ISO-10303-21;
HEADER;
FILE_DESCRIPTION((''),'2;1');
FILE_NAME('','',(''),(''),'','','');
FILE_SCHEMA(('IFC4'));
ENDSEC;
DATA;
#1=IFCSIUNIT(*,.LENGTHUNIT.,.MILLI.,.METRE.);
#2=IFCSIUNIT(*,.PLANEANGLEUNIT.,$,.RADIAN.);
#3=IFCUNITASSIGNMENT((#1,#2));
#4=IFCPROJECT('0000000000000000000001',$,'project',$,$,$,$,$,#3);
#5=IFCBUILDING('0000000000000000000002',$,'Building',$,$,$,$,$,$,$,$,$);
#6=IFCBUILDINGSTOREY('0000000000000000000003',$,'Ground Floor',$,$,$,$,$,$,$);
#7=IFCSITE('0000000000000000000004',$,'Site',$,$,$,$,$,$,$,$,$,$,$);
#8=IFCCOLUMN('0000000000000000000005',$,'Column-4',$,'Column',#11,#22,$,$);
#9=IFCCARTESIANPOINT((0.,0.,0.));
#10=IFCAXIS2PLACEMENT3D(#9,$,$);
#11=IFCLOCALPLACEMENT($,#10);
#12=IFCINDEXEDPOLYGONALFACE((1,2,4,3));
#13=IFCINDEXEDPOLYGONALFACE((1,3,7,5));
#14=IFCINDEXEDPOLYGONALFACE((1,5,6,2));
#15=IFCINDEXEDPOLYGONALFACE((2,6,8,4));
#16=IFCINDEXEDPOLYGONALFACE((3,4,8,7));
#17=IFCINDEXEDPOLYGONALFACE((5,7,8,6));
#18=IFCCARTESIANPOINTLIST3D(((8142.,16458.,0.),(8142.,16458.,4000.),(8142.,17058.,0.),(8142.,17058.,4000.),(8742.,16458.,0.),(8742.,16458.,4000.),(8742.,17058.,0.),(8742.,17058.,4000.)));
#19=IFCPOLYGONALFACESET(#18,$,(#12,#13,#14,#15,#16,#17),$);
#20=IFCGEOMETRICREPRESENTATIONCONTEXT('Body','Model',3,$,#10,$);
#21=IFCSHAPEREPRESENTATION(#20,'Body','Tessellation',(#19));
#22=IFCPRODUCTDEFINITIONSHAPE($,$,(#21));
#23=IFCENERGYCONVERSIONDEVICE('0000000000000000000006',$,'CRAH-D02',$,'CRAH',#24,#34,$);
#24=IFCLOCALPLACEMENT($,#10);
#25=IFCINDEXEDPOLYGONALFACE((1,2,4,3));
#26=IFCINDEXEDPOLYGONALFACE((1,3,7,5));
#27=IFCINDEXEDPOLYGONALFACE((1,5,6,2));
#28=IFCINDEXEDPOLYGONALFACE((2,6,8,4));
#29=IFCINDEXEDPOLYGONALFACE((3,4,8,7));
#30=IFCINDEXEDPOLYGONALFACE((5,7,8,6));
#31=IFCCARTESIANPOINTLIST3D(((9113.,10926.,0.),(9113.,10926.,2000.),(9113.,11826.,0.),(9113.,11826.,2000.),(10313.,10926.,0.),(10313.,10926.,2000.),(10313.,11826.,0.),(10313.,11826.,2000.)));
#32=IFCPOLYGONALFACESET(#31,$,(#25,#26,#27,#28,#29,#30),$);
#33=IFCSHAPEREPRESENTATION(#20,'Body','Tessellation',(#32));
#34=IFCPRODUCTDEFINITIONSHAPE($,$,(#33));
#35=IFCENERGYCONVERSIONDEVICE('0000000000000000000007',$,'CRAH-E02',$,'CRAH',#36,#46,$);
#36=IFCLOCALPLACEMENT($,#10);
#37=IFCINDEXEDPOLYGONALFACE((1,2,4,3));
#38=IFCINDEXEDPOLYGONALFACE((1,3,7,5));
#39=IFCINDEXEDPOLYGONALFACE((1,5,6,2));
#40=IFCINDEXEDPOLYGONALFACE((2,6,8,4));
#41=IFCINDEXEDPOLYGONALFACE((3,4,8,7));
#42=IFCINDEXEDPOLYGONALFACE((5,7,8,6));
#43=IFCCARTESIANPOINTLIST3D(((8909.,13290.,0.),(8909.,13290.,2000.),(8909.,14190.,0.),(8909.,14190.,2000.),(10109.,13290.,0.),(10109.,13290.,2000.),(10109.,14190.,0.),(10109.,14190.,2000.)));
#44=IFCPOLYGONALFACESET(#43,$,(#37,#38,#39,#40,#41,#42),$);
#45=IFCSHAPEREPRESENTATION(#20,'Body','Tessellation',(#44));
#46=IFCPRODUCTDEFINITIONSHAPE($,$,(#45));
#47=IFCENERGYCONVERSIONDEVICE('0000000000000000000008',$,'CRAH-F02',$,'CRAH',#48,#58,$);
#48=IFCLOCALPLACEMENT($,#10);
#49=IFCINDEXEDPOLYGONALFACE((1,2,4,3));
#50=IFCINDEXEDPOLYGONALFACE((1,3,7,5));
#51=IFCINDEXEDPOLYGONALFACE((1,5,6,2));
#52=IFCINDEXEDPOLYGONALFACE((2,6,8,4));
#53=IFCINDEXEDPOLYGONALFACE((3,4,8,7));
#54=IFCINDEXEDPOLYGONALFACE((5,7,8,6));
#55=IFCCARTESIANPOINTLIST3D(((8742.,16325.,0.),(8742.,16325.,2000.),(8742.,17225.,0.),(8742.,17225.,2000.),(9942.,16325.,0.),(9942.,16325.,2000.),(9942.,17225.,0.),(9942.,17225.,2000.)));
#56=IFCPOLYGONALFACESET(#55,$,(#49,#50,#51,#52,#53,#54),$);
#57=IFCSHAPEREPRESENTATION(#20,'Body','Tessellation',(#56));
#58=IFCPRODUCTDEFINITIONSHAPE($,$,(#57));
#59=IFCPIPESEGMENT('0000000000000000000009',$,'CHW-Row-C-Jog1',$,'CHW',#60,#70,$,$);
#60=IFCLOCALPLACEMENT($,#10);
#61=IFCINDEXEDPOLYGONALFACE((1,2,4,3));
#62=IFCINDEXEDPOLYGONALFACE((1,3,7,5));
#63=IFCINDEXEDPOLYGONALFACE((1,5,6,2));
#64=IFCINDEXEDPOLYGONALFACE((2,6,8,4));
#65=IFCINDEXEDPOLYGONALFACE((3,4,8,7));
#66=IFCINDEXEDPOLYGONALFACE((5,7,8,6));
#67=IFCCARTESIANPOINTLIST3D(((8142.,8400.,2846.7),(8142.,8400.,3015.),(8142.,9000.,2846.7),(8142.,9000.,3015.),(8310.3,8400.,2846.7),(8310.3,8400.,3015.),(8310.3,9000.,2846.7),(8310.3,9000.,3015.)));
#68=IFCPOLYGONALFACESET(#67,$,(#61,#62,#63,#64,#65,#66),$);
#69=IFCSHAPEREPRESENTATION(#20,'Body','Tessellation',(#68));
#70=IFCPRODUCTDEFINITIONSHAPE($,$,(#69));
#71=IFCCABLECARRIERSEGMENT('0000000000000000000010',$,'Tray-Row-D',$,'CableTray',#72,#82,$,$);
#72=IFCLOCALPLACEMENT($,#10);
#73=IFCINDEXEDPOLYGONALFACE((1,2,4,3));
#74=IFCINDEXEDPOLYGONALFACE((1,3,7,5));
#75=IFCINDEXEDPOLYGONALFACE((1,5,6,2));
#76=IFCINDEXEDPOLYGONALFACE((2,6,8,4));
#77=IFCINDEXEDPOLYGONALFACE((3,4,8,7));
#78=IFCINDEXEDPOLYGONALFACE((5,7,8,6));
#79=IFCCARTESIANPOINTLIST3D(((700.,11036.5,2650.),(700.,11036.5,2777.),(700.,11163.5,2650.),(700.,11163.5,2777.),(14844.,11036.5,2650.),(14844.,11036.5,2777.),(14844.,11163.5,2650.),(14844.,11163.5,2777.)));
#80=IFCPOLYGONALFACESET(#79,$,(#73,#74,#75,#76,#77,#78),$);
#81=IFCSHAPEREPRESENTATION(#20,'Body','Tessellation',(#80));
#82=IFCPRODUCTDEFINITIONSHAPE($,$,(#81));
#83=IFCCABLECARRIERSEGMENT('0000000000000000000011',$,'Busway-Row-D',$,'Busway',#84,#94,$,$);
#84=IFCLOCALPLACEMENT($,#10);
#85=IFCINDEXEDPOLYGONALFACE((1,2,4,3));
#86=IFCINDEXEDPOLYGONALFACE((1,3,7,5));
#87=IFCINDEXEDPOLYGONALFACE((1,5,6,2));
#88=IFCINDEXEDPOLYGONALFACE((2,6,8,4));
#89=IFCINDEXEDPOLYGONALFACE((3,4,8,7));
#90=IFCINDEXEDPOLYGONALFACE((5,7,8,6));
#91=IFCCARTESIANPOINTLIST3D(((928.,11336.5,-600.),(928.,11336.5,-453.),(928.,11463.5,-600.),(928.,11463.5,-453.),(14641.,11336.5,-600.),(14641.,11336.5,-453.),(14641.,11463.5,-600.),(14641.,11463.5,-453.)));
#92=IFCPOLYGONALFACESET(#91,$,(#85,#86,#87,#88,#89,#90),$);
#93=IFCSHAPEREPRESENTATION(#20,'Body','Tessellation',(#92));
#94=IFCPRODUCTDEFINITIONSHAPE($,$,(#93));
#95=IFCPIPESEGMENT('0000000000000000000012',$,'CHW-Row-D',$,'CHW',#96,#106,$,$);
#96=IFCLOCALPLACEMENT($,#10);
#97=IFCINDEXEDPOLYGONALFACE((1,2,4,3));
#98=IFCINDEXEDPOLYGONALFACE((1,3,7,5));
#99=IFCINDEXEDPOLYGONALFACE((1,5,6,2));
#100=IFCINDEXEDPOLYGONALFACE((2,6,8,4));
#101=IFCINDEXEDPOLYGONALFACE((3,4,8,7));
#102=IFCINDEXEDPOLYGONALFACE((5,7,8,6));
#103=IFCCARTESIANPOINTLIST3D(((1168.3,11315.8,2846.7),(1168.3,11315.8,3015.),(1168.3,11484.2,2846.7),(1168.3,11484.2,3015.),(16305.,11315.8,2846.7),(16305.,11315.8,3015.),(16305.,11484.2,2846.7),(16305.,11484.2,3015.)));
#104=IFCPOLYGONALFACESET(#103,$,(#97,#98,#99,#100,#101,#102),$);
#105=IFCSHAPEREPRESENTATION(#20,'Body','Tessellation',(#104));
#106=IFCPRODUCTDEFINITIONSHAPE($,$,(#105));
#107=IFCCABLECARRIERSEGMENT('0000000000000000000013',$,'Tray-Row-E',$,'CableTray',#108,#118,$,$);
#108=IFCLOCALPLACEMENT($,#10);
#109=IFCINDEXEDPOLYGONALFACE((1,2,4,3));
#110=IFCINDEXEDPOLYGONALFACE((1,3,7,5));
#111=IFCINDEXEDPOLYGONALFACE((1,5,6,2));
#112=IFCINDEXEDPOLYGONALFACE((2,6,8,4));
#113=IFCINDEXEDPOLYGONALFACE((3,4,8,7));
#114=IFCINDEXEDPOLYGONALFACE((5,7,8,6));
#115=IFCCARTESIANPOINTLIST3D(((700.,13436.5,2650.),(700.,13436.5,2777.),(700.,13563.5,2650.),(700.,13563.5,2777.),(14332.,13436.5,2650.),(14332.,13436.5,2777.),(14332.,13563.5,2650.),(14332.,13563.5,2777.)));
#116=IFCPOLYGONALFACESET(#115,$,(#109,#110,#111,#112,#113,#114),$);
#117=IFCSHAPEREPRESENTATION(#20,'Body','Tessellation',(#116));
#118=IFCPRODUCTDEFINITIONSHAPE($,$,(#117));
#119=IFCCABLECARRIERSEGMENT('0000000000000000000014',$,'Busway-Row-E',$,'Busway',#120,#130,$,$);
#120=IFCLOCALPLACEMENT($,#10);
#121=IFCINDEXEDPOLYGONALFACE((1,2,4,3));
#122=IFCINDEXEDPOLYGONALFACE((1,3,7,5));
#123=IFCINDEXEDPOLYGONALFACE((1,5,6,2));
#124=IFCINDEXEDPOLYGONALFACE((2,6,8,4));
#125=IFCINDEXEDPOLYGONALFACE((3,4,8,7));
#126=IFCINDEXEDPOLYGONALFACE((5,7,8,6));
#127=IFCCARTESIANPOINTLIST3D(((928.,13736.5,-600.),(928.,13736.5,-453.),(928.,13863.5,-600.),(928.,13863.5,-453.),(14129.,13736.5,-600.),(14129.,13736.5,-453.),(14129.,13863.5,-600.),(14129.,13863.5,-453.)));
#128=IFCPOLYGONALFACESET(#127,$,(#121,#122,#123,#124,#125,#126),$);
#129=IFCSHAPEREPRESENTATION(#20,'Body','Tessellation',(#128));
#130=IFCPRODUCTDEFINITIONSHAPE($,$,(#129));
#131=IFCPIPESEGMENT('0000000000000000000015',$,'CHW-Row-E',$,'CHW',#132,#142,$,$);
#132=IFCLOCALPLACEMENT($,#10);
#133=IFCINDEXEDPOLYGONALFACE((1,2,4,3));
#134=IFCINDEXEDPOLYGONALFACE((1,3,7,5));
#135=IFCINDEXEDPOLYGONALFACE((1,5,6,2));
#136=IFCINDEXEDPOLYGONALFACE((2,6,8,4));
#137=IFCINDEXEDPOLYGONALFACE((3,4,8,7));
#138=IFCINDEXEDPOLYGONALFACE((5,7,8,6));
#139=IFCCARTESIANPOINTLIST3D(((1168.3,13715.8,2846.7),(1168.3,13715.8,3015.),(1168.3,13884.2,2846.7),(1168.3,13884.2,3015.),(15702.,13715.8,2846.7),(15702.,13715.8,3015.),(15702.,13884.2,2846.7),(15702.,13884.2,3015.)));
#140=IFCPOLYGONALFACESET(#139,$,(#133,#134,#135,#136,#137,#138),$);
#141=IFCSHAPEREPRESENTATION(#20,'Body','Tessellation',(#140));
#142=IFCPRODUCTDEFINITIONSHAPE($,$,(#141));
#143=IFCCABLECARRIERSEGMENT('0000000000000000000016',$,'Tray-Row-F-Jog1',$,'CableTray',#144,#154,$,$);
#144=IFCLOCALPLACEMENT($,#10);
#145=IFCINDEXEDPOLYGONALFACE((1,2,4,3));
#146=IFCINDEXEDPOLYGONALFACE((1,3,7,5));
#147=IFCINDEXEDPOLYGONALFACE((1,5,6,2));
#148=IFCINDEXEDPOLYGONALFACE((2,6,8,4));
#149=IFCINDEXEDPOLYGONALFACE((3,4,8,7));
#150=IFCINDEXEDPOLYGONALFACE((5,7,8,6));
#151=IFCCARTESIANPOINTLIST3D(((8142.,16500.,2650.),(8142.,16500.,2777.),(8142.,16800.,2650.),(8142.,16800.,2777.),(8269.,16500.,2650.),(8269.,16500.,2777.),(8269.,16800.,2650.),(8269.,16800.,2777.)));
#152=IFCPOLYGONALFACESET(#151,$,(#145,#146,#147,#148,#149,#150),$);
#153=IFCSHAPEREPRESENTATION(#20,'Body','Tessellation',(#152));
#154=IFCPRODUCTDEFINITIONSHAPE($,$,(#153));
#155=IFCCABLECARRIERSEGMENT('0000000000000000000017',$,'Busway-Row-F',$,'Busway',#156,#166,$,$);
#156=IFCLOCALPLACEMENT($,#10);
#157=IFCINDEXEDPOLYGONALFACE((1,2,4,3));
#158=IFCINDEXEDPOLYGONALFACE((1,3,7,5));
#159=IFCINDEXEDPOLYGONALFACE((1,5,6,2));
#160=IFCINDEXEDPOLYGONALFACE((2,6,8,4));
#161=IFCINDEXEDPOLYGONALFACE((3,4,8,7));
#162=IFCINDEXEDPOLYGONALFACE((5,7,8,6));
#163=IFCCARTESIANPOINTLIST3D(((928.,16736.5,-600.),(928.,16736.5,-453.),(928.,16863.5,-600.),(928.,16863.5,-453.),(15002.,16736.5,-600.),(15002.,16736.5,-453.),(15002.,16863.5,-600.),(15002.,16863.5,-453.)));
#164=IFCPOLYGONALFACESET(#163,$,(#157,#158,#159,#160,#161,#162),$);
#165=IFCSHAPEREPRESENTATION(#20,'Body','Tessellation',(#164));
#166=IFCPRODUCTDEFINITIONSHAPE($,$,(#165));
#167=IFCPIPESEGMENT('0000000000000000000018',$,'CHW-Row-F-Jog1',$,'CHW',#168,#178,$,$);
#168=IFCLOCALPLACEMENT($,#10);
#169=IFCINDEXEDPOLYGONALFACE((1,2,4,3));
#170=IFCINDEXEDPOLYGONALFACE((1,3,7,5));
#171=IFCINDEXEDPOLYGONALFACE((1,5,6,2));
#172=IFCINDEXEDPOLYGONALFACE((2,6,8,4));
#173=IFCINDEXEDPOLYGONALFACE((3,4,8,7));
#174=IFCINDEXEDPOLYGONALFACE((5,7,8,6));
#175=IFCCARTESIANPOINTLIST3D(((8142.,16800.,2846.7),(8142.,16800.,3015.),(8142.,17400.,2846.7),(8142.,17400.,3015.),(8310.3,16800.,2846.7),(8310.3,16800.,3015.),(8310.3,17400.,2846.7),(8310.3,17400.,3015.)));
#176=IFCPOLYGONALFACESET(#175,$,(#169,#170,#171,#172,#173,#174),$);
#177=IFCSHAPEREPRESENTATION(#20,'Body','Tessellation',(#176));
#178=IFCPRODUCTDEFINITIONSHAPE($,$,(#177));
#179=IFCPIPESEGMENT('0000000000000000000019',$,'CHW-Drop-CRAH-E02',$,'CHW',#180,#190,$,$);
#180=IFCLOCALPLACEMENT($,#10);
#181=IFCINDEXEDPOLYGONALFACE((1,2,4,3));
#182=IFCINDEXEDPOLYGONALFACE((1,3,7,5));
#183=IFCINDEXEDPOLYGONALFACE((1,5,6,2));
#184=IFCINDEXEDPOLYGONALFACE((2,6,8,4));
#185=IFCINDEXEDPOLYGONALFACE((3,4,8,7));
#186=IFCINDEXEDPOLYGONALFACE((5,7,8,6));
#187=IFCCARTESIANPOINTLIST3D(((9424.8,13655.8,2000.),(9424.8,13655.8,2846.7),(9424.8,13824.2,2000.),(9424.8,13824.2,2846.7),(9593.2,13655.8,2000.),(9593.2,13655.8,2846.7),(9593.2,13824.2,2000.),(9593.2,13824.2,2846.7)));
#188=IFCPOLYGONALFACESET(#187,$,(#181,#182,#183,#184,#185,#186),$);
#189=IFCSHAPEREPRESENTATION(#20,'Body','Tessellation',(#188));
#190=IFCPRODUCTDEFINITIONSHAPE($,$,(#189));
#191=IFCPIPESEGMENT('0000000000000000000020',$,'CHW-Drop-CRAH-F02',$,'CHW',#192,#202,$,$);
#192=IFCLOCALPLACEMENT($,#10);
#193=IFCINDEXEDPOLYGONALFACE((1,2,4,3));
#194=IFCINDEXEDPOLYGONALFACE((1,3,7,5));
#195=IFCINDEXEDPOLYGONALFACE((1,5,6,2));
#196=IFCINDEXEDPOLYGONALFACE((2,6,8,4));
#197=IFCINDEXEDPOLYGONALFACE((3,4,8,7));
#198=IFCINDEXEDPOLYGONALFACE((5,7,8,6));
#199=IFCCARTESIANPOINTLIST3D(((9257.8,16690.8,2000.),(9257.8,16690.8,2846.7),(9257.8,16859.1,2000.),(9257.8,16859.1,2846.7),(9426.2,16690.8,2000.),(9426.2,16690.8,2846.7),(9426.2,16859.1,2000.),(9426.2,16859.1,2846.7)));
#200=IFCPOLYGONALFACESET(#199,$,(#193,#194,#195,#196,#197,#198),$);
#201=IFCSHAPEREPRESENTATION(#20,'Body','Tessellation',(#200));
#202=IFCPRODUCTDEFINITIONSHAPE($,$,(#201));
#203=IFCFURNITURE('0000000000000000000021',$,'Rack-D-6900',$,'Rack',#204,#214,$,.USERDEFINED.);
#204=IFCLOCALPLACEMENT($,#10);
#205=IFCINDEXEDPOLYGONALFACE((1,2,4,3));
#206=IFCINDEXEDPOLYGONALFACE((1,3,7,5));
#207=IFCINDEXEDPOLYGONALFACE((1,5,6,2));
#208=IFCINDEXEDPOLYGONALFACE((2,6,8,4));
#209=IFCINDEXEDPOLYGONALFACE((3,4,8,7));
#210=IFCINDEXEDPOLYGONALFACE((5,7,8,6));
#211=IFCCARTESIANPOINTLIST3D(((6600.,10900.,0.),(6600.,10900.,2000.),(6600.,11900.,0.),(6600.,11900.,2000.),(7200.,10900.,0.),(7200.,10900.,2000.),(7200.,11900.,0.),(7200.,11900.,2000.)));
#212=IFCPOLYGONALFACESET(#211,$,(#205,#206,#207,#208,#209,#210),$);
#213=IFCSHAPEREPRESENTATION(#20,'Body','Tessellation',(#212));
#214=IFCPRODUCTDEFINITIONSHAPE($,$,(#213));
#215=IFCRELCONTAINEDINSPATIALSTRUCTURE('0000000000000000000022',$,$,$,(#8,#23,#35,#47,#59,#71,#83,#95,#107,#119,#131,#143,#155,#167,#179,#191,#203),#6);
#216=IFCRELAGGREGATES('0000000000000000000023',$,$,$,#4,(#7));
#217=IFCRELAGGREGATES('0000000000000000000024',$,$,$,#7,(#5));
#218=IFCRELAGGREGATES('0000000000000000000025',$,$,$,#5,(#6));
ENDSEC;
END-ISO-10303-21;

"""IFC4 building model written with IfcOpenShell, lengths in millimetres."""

from ifc_helpers import new_model, si_unit, frame, origin, place, context, project, spatial, rectangle, extrude, element, save


model = new_model("IFC4")

# Units and contexts
model_context = context("Model", 3, world=origin(), identifier="Body")
ifc_project = project(units=[si_unit("LENGTHUNIT", "METRE", prefix="MILLI"), si_unit("PLANEANGLEUNIT", "RADIAN")])

# Site, building, storey
site = spatial("IfcSite", under=ifc_project, Name="Site")
building = spatial("IfcBuilding", under=site, Name="Building")
storey = spatial("IfcBuildingStorey", under=building, Name="Ground Floor")

# Column
column_placement = place(None, frame((8442.0, 16758.0, 0.0), z_axis=(0.0, 0.0, 1.0), x_axis=(1.0, 0.0, 0.0)))
element("IfcColumn", 1, at=column_placement, inside=storey, Name="Column-4", ObjectType="Column", context=model_context, shape_type="SweptSolid", body=[
    extrude(rectangle(XDim=600.0, YDim=600.0), origin(), (0.0, 0.0, 1.0), 4000.0),
])

# Energy conversion devices
for number, where, z_axis, x_axis, name in (
    (2, (9713.0, 11376.0, 0.0), (0.0, 0.0, 1.0), (1.0, 0.0, 0.0), "CRAH-D02"),
    (3, (9509.0, 13740.0, 0.0), (0.0, 0.0, 1.0), (1.0, 0.0, 0.0), "CRAH-E02"),
    (4, (9342.0, 16775.0, 0.0), (0.0, 0.0, 1.0), (1.0, 0.0, 0.0), "CRAH-F02"),
):
    element("IfcEnergyConversionDevice", number, at=place(None, frame(where, z_axis=z_axis, x_axis=x_axis)), inside=storey, Name=name, ObjectType="CRAH", context=model_context, shape_type="SweptSolid", body=[
        extrude(rectangle(XDim=1200.0, YDim=900.0), origin(), (0.0, 0.0, 1.0), 2000.0),
    ])

# Pipe segment
pipe_segment_1_placement = place(None, frame((8226.1, 8700.0, 2846.7), z_axis=(0.0, 0.0, 1.0), x_axis=(1.0, 0.0, 0.0)))
element("IfcPipeSegment", 5, at=pipe_segment_1_placement, inside=storey, Name="CHW-Row-C-Jog1", ObjectType="CHW", context=model_context, shape_type="SweptSolid", body=[
    extrude(rectangle(XDim=168.3, YDim=600.0), origin(), (0.0, 0.0, 1.0), 168.3),
])

# Cable carrier segments
cable_carrier_segment_1_placement = place(None, frame((7772.0, 11100.0, 2650.0), z_axis=(0.0, 0.0, 1.0), x_axis=(1.0, 0.0, 0.0)))
element("IfcCableCarrierSegment", 6, at=cable_carrier_segment_1_placement, inside=storey, Name="Tray-Row-D", ObjectType="CableTray", context=model_context, shape_type="SweptSolid", body=[
    extrude(rectangle(XDim=14144.0, YDim=127.0), origin(), (0.0, 0.0, 1.0), 127.0),
])
cable_carrier_segment_2_placement = place(None, frame((7784.5, 11400.0, -600.0), z_axis=(0.0, 0.0, 1.0), x_axis=(1.0, 0.0, 0.0)))
element("IfcCableCarrierSegment", 7, at=cable_carrier_segment_2_placement, inside=storey, Name="Busway-Row-D", ObjectType="Busway", context=model_context, shape_type="SweptSolid", body=[
    extrude(rectangle(XDim=13713.0, YDim=127.0), origin(), (0.0, 0.0, 1.0), 147.0),
])

# Pipe segment
pipe_segment_2_placement = place(None, frame((8736.6, 11400.0, 2846.7), z_axis=(0.0, 0.0, 1.0), x_axis=(1.0, 0.0, 0.0)))
element("IfcPipeSegment", 8, at=pipe_segment_2_placement, inside=storey, Name="CHW-Row-D", ObjectType="CHW", context=model_context, shape_type="SweptSolid", body=[
    extrude(rectangle(XDim=15136.7, YDim=168.3), origin(), (0.0, 0.0, 1.0), 168.3),
])

# Cable carrier segments
cable_carrier_segment_3_placement = place(None, frame((7516.0, 13500.0, 2650.0), z_axis=(0.0, 0.0, 1.0), x_axis=(1.0, 0.0, 0.0)))
element("IfcCableCarrierSegment", 9, at=cable_carrier_segment_3_placement, inside=storey, Name="Tray-Row-E", ObjectType="CableTray", context=model_context, shape_type="SweptSolid", body=[
    extrude(rectangle(XDim=13632.0, YDim=127.0), origin(), (0.0, 0.0, 1.0), 127.0),
])
cable_carrier_segment_4_placement = place(None, frame((7528.5, 13800.0, -600.0), z_axis=(0.0, 0.0, 1.0), x_axis=(1.0, 0.0, 0.0)))
element("IfcCableCarrierSegment", 10, at=cable_carrier_segment_4_placement, inside=storey, Name="Busway-Row-E", ObjectType="Busway", context=model_context, shape_type="SweptSolid", body=[
    extrude(rectangle(XDim=13201.0, YDim=127.0), origin(), (0.0, 0.0, 1.0), 147.0),
])

# Pipe segment
pipe_segment_3_placement = place(None, frame((8435.1, 13800.0, 2846.7), z_axis=(0.0, 0.0, 1.0), x_axis=(1.0, 0.0, 0.0)))
element("IfcPipeSegment", 11, at=pipe_segment_3_placement, inside=storey, Name="CHW-Row-E", ObjectType="CHW", context=model_context, shape_type="SweptSolid", body=[
    extrude(rectangle(XDim=14533.7, YDim=168.3), origin(), (0.0, 0.0, 1.0), 168.3),
])

# Cable carrier segments
cable_carrier_segment_5_placement = place(None, frame((8205.5, 16650.0, 2650.0), z_axis=(0.0, 0.0, 1.0), x_axis=(1.0, 0.0, 0.0)))
element("IfcCableCarrierSegment", 12, at=cable_carrier_segment_5_placement, inside=storey, Name="Tray-Row-F-Jog1", ObjectType="CableTray", context=model_context, shape_type="SweptSolid", body=[
    extrude(rectangle(XDim=127.0, YDim=300.0), origin(), (0.0, 0.0, 1.0), 127.0),
])
cable_carrier_segment_6_placement = place(None, frame((7965.0, 16800.0, -600.0), z_axis=(0.0, 0.0, 1.0), x_axis=(1.0, 0.0, 0.0)))
element("IfcCableCarrierSegment", 13, at=cable_carrier_segment_6_placement, inside=storey, Name="Busway-Row-F", ObjectType="Busway", context=model_context, shape_type="SweptSolid", body=[
    extrude(rectangle(XDim=14074.0, YDim=127.0), origin(), (0.0, 0.0, 1.0), 147.0),
])

# Pipe segments
pipe_segment_4_placement = place(None, frame((8226.1, 17100.0, 2846.7), z_axis=(0.0, 0.0, 1.0), x_axis=(1.0, 0.0, 0.0)))
element("IfcPipeSegment", 14, at=pipe_segment_4_placement, inside=storey, Name="CHW-Row-F-Jog1", ObjectType="CHW", context=model_context, shape_type="SweptSolid", body=[
    extrude(rectangle(XDim=168.3, YDim=600.0), origin(), (0.0, 0.0, 1.0), 168.3),
])
for number, where, z_axis, x_axis, name in (
    (15, (9509.0, 13740.0, 2000.0), (0.0, 0.0, 1.0), (1.0, 0.0, 0.0), "CHW-Drop-CRAH-E02"),
    (16, (9342.0, 16775.0, 2000.0), (0.0, 0.0, 1.0), (1.0, 0.0, 0.0), "CHW-Drop-CRAH-F02"),
):
    element("IfcPipeSegment", number, at=place(None, frame(where, z_axis=z_axis, x_axis=x_axis)), inside=storey, Name=name, ObjectType="CHW", context=model_context, shape_type="SweptSolid", body=[
        extrude(rectangle(XDim=168.3, YDim=168.3), origin(), (0.0, 0.0, 1.0), 846.7),
    ])

# Furniture
for number, where, z_axis, x_axis, name in (
    (17, (6900.0, 11400.0, 0.0), (0.0, 0.0, 1.0), (1.0, 0.0, 0.0), "Rack-D-6900"),
):
    element("IfcFurniture", number, at=place(None, frame(where, z_axis=z_axis, x_axis=x_axis)), inside=storey, Name=name, ObjectType="Rack", PredefinedType="USERDEFINED", context=model_context, shape_type="SweptSolid", body=[
        extrude(rectangle(XDim=600.0, YDim=1000.0), origin(), (0.0, 0.0, 1.0), 2000.0),
    ])

save(model, "model.ifc")
